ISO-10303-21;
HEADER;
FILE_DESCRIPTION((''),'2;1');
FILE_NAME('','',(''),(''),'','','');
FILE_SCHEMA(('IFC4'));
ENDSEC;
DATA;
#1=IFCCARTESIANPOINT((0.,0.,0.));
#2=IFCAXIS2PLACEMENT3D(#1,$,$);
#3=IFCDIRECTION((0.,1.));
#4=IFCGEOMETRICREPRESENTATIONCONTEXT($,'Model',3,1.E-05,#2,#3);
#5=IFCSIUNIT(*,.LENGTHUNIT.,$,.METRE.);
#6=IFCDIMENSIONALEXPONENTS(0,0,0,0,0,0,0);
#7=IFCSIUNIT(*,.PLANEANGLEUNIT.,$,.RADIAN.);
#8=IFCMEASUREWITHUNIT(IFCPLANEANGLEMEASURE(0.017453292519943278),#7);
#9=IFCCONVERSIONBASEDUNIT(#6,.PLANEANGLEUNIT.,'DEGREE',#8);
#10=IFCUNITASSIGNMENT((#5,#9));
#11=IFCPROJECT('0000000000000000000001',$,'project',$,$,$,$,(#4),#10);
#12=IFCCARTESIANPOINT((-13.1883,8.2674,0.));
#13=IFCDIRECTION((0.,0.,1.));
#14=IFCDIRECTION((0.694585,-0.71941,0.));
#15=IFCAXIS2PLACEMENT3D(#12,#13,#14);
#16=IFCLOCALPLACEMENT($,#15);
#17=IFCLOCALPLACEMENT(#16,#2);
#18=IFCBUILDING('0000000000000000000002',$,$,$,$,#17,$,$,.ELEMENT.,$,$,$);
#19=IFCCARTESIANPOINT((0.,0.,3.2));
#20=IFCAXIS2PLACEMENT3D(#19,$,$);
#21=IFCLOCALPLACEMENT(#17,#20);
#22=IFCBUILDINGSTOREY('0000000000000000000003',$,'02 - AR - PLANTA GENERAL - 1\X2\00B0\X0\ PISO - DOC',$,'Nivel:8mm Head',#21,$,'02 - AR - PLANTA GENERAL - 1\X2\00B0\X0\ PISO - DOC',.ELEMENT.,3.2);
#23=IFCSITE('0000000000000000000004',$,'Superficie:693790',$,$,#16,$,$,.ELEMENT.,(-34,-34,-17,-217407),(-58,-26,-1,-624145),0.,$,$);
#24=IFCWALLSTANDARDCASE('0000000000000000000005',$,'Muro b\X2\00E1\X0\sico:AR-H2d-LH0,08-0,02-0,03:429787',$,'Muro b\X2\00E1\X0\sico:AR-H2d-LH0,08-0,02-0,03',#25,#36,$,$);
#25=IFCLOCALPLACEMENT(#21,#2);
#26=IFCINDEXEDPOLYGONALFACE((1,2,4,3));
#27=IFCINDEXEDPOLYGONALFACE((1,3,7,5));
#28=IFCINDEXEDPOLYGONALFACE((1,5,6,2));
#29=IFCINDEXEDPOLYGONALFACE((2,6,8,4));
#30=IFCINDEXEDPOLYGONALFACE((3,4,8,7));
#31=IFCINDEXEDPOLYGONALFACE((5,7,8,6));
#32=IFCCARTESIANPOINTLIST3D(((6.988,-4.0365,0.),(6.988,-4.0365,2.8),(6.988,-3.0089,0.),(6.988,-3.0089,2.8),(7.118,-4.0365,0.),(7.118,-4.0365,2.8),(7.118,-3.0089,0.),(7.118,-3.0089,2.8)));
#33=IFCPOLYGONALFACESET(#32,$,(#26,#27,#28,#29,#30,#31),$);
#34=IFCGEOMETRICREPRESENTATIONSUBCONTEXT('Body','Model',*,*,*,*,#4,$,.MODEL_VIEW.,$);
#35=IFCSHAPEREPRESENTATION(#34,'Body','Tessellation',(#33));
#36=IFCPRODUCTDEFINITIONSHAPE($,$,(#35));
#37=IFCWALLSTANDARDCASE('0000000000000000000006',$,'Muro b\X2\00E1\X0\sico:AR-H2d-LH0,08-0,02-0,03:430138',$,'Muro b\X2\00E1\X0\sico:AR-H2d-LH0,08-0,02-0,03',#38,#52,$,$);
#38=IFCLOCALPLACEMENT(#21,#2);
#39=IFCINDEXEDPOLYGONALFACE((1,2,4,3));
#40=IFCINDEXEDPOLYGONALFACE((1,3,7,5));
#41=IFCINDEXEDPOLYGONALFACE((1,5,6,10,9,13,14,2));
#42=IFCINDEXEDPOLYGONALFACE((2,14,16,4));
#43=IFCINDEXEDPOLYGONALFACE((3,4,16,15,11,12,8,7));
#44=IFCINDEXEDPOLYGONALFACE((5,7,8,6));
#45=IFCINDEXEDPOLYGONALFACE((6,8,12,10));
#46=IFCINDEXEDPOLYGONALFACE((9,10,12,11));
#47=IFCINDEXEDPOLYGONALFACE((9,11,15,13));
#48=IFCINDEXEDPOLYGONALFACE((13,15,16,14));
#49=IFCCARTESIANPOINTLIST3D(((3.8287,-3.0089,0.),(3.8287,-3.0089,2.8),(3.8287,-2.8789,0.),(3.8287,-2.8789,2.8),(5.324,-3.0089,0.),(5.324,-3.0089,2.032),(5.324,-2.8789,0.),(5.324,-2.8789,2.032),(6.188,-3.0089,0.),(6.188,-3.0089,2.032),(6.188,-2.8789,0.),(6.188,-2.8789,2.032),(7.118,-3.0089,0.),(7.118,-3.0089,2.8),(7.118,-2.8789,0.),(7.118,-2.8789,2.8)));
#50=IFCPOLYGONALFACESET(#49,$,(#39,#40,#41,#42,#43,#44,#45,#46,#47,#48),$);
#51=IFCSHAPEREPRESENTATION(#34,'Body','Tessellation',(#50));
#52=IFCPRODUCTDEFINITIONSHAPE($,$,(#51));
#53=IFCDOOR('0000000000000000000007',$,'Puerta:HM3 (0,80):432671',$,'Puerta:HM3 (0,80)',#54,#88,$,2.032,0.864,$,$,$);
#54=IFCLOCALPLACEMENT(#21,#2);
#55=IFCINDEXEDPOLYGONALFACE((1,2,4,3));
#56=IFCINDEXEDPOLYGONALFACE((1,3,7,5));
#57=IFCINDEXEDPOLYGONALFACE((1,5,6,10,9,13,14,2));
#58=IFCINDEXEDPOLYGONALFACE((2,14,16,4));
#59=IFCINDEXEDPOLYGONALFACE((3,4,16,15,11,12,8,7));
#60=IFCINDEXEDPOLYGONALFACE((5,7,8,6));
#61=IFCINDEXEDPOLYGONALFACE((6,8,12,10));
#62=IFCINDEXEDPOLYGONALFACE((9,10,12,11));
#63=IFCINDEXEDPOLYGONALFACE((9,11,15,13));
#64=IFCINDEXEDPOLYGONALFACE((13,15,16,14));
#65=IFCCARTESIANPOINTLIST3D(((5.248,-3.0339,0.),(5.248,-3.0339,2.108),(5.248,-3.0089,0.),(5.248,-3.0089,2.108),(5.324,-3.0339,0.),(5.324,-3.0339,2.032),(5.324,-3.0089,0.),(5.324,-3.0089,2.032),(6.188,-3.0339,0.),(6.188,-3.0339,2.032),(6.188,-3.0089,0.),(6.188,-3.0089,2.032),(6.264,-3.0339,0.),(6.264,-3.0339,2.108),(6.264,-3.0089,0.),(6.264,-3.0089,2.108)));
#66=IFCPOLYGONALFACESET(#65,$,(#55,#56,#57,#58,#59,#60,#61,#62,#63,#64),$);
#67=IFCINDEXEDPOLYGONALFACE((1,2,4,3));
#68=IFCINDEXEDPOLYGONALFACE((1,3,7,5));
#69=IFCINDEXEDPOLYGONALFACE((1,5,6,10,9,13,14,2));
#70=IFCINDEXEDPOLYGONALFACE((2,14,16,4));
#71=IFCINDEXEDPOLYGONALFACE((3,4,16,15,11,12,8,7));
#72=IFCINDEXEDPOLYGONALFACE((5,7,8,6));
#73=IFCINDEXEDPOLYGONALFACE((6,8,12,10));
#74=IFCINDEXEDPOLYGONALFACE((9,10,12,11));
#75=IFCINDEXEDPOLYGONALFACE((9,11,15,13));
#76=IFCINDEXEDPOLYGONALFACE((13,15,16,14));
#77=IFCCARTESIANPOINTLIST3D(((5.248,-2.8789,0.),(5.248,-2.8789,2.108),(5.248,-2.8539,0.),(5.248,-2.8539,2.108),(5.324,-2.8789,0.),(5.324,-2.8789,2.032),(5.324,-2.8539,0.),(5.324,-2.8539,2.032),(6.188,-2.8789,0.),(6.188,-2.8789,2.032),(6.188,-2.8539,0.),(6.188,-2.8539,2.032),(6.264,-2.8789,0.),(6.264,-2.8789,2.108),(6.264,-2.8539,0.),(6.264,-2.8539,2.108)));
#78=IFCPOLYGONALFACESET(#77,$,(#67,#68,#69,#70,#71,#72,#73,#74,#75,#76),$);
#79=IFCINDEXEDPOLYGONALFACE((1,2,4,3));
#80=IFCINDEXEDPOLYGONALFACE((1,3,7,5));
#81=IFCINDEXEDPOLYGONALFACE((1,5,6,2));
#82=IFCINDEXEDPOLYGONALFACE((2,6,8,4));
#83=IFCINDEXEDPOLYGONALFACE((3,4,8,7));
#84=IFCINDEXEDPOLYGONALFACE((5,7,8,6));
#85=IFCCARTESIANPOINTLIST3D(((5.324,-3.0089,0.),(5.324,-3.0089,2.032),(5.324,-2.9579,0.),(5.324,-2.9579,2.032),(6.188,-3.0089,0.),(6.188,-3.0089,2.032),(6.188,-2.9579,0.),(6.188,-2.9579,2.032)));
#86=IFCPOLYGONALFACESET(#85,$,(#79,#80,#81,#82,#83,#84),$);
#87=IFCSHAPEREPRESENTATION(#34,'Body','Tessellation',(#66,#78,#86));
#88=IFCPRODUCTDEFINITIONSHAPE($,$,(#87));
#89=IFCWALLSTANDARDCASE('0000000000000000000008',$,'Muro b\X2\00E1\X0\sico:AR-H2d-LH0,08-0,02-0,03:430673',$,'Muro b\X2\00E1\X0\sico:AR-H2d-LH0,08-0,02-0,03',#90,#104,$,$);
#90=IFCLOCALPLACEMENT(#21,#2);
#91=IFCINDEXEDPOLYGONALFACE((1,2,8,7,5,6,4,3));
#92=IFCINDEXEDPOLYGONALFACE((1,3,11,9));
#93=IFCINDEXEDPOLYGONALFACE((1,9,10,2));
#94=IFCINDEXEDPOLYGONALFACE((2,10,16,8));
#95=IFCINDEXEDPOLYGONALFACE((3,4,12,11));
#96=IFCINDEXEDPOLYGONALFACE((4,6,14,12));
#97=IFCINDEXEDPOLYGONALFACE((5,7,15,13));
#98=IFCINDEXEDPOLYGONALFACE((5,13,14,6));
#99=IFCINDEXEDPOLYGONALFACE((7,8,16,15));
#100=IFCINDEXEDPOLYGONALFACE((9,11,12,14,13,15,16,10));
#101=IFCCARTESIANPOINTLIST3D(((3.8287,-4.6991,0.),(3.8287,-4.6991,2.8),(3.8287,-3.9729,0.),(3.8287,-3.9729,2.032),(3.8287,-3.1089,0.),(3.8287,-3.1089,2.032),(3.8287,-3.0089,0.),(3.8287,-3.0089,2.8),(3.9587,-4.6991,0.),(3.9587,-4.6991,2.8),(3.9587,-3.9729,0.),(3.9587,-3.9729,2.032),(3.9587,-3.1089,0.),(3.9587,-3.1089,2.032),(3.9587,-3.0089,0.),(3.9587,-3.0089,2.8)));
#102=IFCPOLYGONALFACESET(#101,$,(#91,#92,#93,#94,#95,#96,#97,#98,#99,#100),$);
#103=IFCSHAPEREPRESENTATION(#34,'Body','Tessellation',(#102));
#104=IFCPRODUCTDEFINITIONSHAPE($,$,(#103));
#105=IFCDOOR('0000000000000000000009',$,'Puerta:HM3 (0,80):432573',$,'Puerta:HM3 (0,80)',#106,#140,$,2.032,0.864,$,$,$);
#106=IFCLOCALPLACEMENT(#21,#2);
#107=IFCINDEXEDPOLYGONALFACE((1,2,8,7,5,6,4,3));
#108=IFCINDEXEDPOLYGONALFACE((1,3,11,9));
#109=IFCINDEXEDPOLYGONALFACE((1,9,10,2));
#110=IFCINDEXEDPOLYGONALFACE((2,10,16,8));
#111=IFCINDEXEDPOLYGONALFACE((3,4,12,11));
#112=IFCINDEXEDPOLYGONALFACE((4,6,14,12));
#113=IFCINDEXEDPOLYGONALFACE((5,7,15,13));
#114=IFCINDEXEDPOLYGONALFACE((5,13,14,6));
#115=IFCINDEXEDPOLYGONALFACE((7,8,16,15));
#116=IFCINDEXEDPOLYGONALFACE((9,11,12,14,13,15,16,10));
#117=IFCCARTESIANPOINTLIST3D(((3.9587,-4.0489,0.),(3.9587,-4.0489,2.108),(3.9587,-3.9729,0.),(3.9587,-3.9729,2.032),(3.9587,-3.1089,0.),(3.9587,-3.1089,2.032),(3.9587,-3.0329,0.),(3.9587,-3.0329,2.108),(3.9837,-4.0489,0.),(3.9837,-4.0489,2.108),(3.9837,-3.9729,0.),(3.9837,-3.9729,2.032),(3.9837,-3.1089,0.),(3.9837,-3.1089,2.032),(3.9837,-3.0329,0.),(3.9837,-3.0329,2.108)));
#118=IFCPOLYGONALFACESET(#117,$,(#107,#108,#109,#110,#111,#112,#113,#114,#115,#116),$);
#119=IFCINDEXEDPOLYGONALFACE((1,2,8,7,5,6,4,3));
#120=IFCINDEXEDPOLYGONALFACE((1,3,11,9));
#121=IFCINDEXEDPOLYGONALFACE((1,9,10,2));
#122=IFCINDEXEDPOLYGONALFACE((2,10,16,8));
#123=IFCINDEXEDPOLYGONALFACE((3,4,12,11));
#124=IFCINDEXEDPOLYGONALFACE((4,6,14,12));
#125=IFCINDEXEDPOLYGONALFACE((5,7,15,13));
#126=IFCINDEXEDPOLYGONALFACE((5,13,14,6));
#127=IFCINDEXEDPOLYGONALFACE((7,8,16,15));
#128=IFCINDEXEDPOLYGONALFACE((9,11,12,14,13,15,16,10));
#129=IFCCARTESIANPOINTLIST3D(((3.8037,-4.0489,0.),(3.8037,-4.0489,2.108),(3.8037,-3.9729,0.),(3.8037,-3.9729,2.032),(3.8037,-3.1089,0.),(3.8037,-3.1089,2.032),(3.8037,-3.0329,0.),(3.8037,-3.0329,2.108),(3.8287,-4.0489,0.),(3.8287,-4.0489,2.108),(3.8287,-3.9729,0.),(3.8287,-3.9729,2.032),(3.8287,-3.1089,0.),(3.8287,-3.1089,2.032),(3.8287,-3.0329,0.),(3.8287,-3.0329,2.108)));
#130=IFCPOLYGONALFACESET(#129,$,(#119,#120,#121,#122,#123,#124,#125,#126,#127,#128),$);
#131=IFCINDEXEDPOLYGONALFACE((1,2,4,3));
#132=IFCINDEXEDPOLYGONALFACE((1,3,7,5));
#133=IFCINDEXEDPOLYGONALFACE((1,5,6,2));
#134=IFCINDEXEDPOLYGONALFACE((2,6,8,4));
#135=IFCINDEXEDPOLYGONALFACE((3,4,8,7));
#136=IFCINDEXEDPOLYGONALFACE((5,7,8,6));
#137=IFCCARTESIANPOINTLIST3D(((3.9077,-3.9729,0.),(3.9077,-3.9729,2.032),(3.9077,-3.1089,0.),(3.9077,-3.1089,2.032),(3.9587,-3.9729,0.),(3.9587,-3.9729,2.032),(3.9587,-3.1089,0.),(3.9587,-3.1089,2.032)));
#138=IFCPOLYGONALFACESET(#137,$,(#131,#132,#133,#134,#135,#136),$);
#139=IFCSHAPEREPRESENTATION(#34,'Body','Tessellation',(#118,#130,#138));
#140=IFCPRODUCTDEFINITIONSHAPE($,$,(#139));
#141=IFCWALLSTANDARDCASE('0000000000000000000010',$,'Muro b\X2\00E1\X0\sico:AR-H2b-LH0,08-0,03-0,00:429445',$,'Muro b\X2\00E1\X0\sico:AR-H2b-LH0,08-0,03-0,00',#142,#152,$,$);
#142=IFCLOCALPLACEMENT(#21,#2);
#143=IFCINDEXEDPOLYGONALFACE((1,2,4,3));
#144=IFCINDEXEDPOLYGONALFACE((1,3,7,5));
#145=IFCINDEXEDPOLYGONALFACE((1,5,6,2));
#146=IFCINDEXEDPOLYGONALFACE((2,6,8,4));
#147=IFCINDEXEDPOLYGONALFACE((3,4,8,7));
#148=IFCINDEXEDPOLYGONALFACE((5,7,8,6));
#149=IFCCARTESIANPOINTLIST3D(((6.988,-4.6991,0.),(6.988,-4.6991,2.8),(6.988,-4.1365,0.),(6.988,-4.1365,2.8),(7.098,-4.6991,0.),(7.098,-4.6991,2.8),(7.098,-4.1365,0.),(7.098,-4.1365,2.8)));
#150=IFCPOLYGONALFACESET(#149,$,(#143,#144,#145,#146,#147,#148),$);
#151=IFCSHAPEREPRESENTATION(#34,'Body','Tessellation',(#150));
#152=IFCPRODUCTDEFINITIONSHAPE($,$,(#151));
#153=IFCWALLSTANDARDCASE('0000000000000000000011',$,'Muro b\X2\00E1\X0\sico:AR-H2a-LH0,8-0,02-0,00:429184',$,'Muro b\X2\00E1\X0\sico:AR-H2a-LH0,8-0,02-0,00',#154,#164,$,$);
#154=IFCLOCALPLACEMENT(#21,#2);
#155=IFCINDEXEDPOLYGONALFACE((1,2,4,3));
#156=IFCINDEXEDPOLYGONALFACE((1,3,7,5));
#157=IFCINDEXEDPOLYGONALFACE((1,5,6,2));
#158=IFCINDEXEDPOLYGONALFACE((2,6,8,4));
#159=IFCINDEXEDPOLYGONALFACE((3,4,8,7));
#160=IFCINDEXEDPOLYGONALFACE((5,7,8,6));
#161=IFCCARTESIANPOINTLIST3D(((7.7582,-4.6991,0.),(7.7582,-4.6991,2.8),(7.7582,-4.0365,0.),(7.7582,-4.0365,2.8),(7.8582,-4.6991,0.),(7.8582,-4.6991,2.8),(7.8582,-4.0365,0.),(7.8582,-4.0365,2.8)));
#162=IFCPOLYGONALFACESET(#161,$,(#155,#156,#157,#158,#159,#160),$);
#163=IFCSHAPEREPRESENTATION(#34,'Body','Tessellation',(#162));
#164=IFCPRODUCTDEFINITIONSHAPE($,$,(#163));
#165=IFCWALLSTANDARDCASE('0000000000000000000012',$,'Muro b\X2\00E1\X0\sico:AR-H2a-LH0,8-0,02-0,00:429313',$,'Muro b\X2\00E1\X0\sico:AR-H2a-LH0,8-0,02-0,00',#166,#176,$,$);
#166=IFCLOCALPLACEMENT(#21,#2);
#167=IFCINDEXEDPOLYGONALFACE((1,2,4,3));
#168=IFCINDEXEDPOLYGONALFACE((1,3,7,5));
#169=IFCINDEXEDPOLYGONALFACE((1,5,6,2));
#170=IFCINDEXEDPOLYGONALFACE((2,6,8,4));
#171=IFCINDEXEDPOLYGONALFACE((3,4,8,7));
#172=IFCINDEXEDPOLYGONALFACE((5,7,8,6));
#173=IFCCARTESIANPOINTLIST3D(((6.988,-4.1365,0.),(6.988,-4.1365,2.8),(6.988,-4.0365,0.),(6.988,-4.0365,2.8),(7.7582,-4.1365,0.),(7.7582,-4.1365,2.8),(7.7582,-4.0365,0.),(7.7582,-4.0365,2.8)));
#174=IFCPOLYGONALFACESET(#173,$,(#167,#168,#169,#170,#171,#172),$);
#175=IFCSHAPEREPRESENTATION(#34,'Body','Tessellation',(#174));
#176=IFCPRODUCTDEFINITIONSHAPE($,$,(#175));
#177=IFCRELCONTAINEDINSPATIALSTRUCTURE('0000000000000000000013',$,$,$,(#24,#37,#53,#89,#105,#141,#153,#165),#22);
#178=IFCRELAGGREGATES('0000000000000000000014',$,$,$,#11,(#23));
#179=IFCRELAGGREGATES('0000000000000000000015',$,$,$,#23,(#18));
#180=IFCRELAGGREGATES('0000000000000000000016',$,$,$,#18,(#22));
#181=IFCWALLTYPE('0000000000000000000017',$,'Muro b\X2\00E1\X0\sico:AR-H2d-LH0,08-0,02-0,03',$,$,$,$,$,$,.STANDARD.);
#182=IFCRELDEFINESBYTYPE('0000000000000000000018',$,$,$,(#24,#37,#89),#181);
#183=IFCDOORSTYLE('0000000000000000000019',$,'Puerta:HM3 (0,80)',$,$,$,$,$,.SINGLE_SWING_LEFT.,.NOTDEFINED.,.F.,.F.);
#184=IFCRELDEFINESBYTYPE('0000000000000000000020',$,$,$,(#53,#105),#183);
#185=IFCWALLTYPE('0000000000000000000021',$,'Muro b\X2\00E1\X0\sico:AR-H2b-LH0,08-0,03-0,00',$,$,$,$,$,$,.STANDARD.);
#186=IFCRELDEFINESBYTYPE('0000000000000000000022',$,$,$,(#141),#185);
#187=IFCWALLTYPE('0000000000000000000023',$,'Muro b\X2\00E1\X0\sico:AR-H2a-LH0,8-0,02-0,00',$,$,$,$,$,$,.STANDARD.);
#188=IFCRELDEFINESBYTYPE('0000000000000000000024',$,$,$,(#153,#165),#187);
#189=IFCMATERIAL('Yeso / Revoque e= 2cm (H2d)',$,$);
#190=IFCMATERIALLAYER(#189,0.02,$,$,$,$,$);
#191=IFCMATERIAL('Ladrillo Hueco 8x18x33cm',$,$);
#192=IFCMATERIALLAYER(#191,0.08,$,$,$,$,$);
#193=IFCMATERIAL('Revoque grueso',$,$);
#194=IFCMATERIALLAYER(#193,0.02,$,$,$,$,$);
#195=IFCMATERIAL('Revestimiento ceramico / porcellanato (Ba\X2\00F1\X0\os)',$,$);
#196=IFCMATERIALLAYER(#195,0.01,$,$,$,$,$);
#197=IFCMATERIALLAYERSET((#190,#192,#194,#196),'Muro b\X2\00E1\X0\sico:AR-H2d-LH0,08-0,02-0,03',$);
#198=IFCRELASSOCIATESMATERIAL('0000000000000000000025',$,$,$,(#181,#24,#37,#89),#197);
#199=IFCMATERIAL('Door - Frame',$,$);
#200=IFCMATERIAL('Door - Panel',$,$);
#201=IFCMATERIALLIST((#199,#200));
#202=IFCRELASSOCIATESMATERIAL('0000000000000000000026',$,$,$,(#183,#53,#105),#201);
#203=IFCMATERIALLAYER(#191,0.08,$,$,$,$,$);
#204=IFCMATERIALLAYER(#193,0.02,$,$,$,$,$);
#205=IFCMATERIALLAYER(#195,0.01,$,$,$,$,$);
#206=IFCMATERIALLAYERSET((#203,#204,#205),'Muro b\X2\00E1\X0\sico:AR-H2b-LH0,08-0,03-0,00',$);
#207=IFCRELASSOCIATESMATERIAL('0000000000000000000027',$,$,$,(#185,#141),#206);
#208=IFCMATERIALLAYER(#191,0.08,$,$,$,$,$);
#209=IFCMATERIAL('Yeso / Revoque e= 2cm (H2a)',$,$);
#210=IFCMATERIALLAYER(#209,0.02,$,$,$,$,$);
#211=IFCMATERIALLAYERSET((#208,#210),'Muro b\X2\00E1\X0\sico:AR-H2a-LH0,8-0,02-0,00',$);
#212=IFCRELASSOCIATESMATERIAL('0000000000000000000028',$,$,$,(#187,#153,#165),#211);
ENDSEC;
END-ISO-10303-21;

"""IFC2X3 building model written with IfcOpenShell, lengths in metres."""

from ifc_helpers import new_model, entity, si_unit, converted_unit, direction, frame, frame_2d, origin, place, context, subcontext, project, spatial, polyline, rectangle, outline, extrude, source, transform, mapped, material, material_list, layer, layer_set, layer_usage, type_object, type_shapes, element, fill, save


model = new_model("IFC2X3")

# Units and contexts
model_context = context("Model", 3, precision=1e-05, world=origin(), true_north=direction((0.0, 1.0)))
body_context = subcontext(model_context, "Body", "Model", "MODEL_VIEW")
ifc_project = project(units=[si_unit("LENGTHUNIT", "METRE"), converted_unit("PLANEANGLEUNIT", "DEGREE", entity("IfcPlaneAngleMeasure", 0.017453292519943278), si_unit("PLANEANGLEUNIT", "RADIAN"), dimensions=[0, 0, 0, 0, 0, 0, 0])], contexts=[model_context])

# Site, building, storey
site_placement = place(None, frame((-13.1883, 8.2674, 0.0), z_axis=(0.0, 0.0, 1.0), x_axis=(0.694585, -0.71941, 0.0)))
site = spatial("IfcSite", under=ifc_project, at=site_placement, Name="Superficie:693790", CompositionType="ELEMENT", RefLatitude=(-34, -34, -17, -217407), RefLongitude=(-58, -26, -1, -624145), RefElevation=0.0)
building_placement = place(site_placement, origin())
building = spatial("IfcBuilding", under=site, at=building_placement, CompositionType="ELEMENT")
storey_placement = place(building_placement, frame((0.0, 0.0, 3.2)))
storey = spatial("IfcBuildingStorey", under=building, at=storey_placement, Name="02 - AR - PLANTA GENERAL - 1° PISO - DOC", ObjectType="Nivel:8mm Head", LongName="02 - AR - PLANTA GENERAL - 1° PISO - DOC", CompositionType="ELEMENT", Elevation=3.2)

# Wall
ifc_material_1 = material(Name="Yeso / Revoque e= 2cm (H2d)")
ifc_layer_1 = layer(ifc_material_1, 0.02)
ifc_material_2 = material(Name="Ladrillo Hueco 8x18x33cm")
ifc_layer_2 = layer(ifc_material_2, 0.08)
ifc_material_3 = material(Name="Revoque grueso")
ifc_layer_3 = layer(ifc_material_3, 0.02)
ifc_material_4 = material(Name="Revestimiento ceramico / porcellanato (Baños)")
ifc_layer_4 = layer(ifc_material_4, 0.01)
ifc_layer_set_1 = layer_set([ifc_layer_1, ifc_layer_2, ifc_layer_3, ifc_layer_4], Name="Muro básico:AR-H2d-LH0,08-0,02-0,03")
ifc_layer_usage_1 = layer_usage(ifc_layer_set_1, "AXIS2", "POSITIVE", -0.065)
wall_type_1 = type_object("IfcWallType", Name="Muro básico:AR-H2d-LH0,08-0,02-0,03", PredefinedType="STANDARD", material=ifc_layer_set_1)
wall_1_placement = place(storey_placement, frame((7.053, -4.0365, 0.0), z_axis=(0.0, 0.0, 1.0), x_axis=(0.0, 1.0, 0.0)))
element("IfcWallStandardCase", 1, at=wall_1_placement, inside=storey, type_object=wall_type_1, material=ifc_layer_usage_1, Name="Muro básico:AR-H2d-LH0,08-0,02-0,03:429787", ObjectType="Muro básico:AR-H2d-LH0,08-0,02-0,03", context=body_context, shape_type="SweptSolid", body=[
    extrude(rectangle(XDim=1.0276, YDim=0.13, at=frame_2d((0.5138, 0.0), x_axis=(-1.0, 0.0))), origin(), (0.0, 0.0, 1.0), 2.8),
])

# Walls, openings, doors
ifc_layer_usage_2 = layer_usage(ifc_layer_set_1, "AXIS2", "NEGATIVE", 0.065)
wall_2_placement = place(storey_placement, frame((7.118, -2.9439, 0.0), z_axis=(0.0, 0.0, 1.0), x_axis=(-1.0, 0.0, 0.0)))
wall_2 = element("IfcWallStandardCase", 2, at=wall_2_placement, inside=storey, type_object=wall_type_1, material=ifc_layer_usage_2, Name="Muro básico:AR-H2d-LH0,08-0,02-0,03:430138", ObjectType="Muro básico:AR-H2d-LH0,08-0,02-0,03", context=body_context, shape_type="SweptSolid", body=[
    extrude(rectangle(XDim=3.2893, YDim=0.13, at=frame_2d((1.6446, 0.0), x_axis=(1.0, 0.0))), origin(), (0.0, 0.0, 1.0), 2.8),
])
opening_1_placement = place(wall_2_placement, frame((0.93, -0.065, 0.0)))
opening_1 = element("IfcOpeningElement", 3, at=opening_1_placement, cuts=wall_2, ObjectType="Opening", context=body_context, shape_type="SweptSolid", body=[
    extrude(rectangle(XDim=0.864, YDim=2.032, at=frame_2d((1.016, 0.432), x_axis=(0.0, -1.0))), frame((0.0, 0.0, 0.0), z_axis=(0.0, 1.0, 0.0), x_axis=(0.0, 0.0, 1.0)), (0.0, 0.0, 1.0), 0.13),
])
ifc_material_5 = material(Name="Door - Frame")
ifc_material_6 = material(Name="Door - Panel")
ifc_material_list = material_list([ifc_material_5, ifc_material_6])
door_style = type_object("IfcDoorStyle", Name="Puerta:HM3 (0,80)", ConstructionType="NOTDEFINED", OperationType="SINGLE_SWING_LEFT", ParameterTakesPrecedence=False, Sizeable=False, material=ifc_material_list)
shared_shape_1 = source(origin(), body_context, "Body", "SweptSolid", [
    extrude(outline(polyline([(-0.508, -1.073), (0.508, -1.073), (0.508, 1.035), (0.432, 1.035), (0.432, -0.997), (-0.432, -0.997), (-0.432, 1.035), (-0.508, 1.035), (-0.508, -1.073)])), frame((0.432, 0.155, 1.035), z_axis=(0.0, -1.0, 0.0), x_axis=(-1.0, 0.0, 0.0)), (0.0, 0.0, 1.0), 0.025),
    extrude(outline(polyline([(-1.073, -0.508), (1.035, -0.508), (1.035, -0.432), (-0.997, -0.432), (-0.997, 0.432), (1.035, 0.432), (1.035, 0.508), (-1.073, 0.508), (-1.073, -0.508)])), frame((0.432, 0.0, 1.035), z_axis=(0.0, -1.0, 0.0), x_axis=(0.0, 0.0, -1.0)), (0.0, 0.0, 1.0), 0.025),
    extrude(rectangle(XDim=0.864, YDim=0.051, at=frame_2d((0.0, 0.0), x_axis=(1.0, 0.0))), frame((0.432, 0.1045, 0.0)), (0.0, 0.0, 1.0), 2.032),
])
type_shapes(door_style, [shared_shape_1])
door_1_placement = place(opening_1_placement, origin())
door_1 = element("IfcDoor", 4, at=door_1_placement, inside=storey, type_object=door_style, material=ifc_material_list, Name="Puerta:HM3 (0,80):432671", ObjectType="Puerta:HM3 (0,80)", OverallHeight=2.032, OverallWidth=0.864, context=body_context, shape_type="MappedRepresentation", body=[
    mapped(shared_shape_1, transform((0.0, 0.0, 0.0), scale=1.0)),
])
fill(opening_1, door_1)
ifc_layer_usage_3 = layer_usage(ifc_layer_set_1, "AXIS2", "NEGATIVE", 0.065)
wall_3_placement = place(storey_placement, frame((3.8937, -4.6991, 0.0), z_axis=(0.0, 0.0, 1.0), x_axis=(0.0, 1.0, 0.0)))
wall_3 = element("IfcWallStandardCase", 5, at=wall_3_placement, inside=storey, type_object=wall_type_1, material=ifc_layer_usage_3, Name="Muro básico:AR-H2d-LH0,08-0,02-0,03:430673", ObjectType="Muro básico:AR-H2d-LH0,08-0,02-0,03", context=body_context, shape_type="SweptSolid", body=[
    extrude(rectangle(XDim=1.6902, YDim=0.13, at=frame_2d((0.8451, 0.0), x_axis=(1.0, 0.0))), origin(), (0.0, 0.0, 1.0), 2.8),
])
opening_2_placement = place(wall_3_placement, frame((1.5902, 0.065, 0.0)))
opening_2 = element("IfcOpeningElement", 6, at=opening_2_placement, cuts=wall_3, ObjectType="Opening", context=body_context, shape_type="SweptSolid", body=[
    extrude(rectangle(XDim=0.864, YDim=2.032, at=frame_2d((1.016, 0.432), x_axis=(0.0, -1.0))), frame((0.0, 0.0, 0.0), z_axis=(0.0, -1.0, 0.0), x_axis=(0.0, 0.0, 1.0)), (0.0, 0.0, 1.0), 0.13),
])
door_2_placement = place(opening_2_placement, frame((0.0, 0.0, 0.0), z_axis=(0.0, 0.0, 1.0), x_axis=(-1.0, 0.0, 0.0)))
door_2 = element("IfcDoor", 7, at=door_2_placement, inside=storey, type_object=door_style, material=ifc_material_list, Name="Puerta:HM3 (0,80):432573", ObjectType="Puerta:HM3 (0,80)", OverallHeight=2.032, OverallWidth=0.864, context=body_context, shape_type="MappedRepresentation", body=[
    mapped(shared_shape_1, transform((0.0, 0.0, 0.0), scale=1.0)),
])
fill(opening_2, door_2)

# Walls
ifc_layer_5 = layer(ifc_material_2, 0.08)
ifc_layer_6 = layer(ifc_material_3, 0.02)
ifc_layer_7 = layer(ifc_material_4, 0.01)
ifc_layer_set_2 = layer_set([ifc_layer_5, ifc_layer_6, ifc_layer_7], Name="Muro básico:AR-H2b-LH0,08-0,03-0,00")
ifc_layer_usage_4 = layer_usage(ifc_layer_set_2, "AXIS2", "POSITIVE", -0.055)
wall_type_2 = type_object("IfcWallType", Name="Muro básico:AR-H2b-LH0,08-0,03-0,00", PredefinedType="STANDARD", material=ifc_layer_set_2)
wall_4_placement = place(storey_placement, frame((7.043, -4.6991, 0.0), z_axis=(0.0, 0.0, 1.0), x_axis=(0.0, 1.0, 0.0)))
element("IfcWallStandardCase", 8, at=wall_4_placement, inside=storey, type_object=wall_type_2, material=ifc_layer_usage_4, Name="Muro básico:AR-H2b-LH0,08-0,03-0,00:429445", ObjectType="Muro básico:AR-H2b-LH0,08-0,03-0,00", context=body_context, shape_type="SweptSolid", body=[
    extrude(rectangle(XDim=0.5626, YDim=0.11, at=frame_2d((0.2813, 0.0), x_axis=(-1.0, 0.0))), origin(), (0.0, 0.0, 1.0), 2.8),
])
ifc_layer_8 = layer(ifc_material_2, 0.08)
ifc_material_7 = material(Name="Yeso / Revoque e= 2cm (H2a)")
ifc_layer_9 = layer(ifc_material_7, 0.02)
ifc_layer_set_3 = layer_set([ifc_layer_8, ifc_layer_9], Name="Muro básico:AR-H2a-LH0,8-0,02-0,00")
ifc_layer_usage_5 = layer_usage(ifc_layer_set_3, "AXIS2", "NEGATIVE", 0.05)
wall_type_3 = type_object("IfcWallType", Name="Muro básico:AR-H2a-LH0,8-0,02-0,00", PredefinedType="STANDARD", material=ifc_layer_set_3)
wall_5_placement = place(storey_placement, frame((7.8082, -4.6991, 0.0), z_axis=(0.0, 0.0, 1.0), x_axis=(0.0, 1.0, 0.0)))
element("IfcWallStandardCase", 9, at=wall_5_placement, inside=storey, type_object=wall_type_3, material=ifc_layer_usage_5, Name="Muro básico:AR-H2a-LH0,8-0,02-0,00:429184", ObjectType="Muro básico:AR-H2a-LH0,8-0,02-0,00", context=body_context, shape_type="SweptSolid", body=[
    extrude(rectangle(XDim=0.6626, YDim=0.1, at=frame_2d((0.3313, 0.0), x_axis=(-1.0, 0.0))), origin(), (0.0, 0.0, 1.0), 2.8),
])
ifc_layer_usage_6 = layer_usage(ifc_layer_set_3, "AXIS2", "NEGATIVE", 0.05)
wall_6_placement = place(storey_placement, frame((7.7582, -4.0865, 0.0), z_axis=(0.0, 0.0, 1.0), x_axis=(-1.0, 0.0, 0.0)))
element("IfcWallStandardCase", 10, at=wall_6_placement, inside=storey, type_object=wall_type_3, material=ifc_layer_usage_6, Name="Muro básico:AR-H2a-LH0,8-0,02-0,00:429313", ObjectType="Muro básico:AR-H2a-LH0,8-0,02-0,00", context=body_context, shape_type="SweptSolid", body=[
    extrude(rectangle(XDim=0.7703, YDim=0.1, at=frame_2d((0.3851, 0.0), x_axis=(-1.0, 0.0))), origin(), (0.0, 0.0, 1.0), 2.8),
])

save(model, "model.ifc")
